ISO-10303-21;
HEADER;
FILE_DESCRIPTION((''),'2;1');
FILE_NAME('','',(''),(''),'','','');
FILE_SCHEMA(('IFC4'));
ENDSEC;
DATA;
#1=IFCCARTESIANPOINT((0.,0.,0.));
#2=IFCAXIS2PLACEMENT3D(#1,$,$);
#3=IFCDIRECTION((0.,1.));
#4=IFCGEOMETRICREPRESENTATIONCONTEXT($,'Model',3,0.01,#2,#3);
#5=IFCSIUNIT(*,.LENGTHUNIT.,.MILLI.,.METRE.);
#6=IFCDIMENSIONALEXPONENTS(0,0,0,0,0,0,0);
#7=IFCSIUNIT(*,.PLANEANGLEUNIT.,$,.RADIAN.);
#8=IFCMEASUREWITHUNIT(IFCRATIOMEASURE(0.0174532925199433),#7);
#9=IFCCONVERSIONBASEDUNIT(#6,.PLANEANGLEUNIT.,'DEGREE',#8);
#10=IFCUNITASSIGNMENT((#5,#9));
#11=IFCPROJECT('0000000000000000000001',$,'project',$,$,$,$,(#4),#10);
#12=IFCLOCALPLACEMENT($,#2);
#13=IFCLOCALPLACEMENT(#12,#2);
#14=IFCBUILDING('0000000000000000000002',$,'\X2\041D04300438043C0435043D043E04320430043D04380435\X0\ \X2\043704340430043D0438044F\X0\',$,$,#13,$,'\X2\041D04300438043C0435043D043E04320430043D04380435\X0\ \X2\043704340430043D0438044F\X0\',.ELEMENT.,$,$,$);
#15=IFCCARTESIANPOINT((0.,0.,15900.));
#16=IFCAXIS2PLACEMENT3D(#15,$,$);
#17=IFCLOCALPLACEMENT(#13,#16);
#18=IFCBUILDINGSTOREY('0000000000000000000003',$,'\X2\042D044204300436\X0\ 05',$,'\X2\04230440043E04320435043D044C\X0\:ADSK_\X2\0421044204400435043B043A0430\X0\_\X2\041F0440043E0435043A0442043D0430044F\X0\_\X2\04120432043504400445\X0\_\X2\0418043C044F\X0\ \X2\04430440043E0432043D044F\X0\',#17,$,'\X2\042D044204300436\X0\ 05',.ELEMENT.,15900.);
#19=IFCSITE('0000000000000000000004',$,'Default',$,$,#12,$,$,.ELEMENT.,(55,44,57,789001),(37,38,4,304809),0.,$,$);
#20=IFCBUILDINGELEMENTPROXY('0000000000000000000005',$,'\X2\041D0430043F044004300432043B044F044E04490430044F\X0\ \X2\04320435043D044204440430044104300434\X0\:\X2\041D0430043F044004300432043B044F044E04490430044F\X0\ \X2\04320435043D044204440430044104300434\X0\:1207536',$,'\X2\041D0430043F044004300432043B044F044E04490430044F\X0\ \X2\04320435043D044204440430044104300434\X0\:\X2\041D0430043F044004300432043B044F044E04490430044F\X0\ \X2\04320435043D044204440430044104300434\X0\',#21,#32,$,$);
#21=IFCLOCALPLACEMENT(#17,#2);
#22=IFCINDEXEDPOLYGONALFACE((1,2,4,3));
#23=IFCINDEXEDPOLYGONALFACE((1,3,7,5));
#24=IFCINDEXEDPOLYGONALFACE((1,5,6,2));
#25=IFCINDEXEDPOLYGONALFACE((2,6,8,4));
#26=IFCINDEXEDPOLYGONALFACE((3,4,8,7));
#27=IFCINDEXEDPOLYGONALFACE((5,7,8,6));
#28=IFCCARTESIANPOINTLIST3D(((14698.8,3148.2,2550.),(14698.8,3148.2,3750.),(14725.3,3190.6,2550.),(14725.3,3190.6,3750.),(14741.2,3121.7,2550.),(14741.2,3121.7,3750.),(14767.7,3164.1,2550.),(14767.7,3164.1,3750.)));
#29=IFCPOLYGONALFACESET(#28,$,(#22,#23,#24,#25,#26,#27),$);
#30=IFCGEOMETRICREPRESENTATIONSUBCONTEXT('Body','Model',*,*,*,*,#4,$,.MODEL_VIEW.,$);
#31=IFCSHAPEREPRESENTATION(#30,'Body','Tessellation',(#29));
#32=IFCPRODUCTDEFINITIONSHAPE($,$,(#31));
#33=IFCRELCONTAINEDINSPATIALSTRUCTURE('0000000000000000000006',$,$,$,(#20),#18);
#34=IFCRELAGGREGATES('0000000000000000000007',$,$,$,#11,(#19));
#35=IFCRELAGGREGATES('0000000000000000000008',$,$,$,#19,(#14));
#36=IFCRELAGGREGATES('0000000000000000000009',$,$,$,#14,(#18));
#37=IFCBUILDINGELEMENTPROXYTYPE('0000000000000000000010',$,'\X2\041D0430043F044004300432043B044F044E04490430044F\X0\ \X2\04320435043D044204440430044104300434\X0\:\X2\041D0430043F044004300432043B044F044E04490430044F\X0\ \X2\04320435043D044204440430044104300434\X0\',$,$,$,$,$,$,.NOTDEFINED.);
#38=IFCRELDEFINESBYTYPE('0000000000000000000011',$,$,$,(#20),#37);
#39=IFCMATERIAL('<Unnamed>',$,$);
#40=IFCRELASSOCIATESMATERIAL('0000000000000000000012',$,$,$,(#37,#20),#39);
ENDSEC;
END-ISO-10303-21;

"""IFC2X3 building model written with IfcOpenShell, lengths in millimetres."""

from ifc_helpers import new_model, entity, si_unit, converted_unit, direction, frame, origin, origin_2d_with_axis, place, context, subcontext, project, spatial, rectangle, extrude, source, transform, mapped, material, type_object, type_shapes, element, save


model = new_model("IFC2X3")

# Units and contexts
model_context = context("Model", 3, precision=0.01, world=origin(), true_north=direction((0.0, 1.0)))
body_context = subcontext(model_context, "Body", "Model", "MODEL_VIEW")
ifc_project = project(units=[si_unit("LENGTHUNIT", "METRE", prefix="MILLI"), converted_unit("PLANEANGLEUNIT", "DEGREE", entity("IfcRatioMeasure", 0.0174532925199433), si_unit("PLANEANGLEUNIT", "RADIAN"), dimensions=[0, 0, 0, 0, 0, 0, 0])], contexts=[model_context])

# Site, building, storey
site_placement = place(None, origin())
site = spatial("IfcSite", under=ifc_project, at=site_placement, Name="Default", CompositionType="ELEMENT", RefLatitude=(55, 44, 57, 789001), RefLongitude=(37, 38, 4, 304809), RefElevation=0.0)
building_placement = place(site_placement, origin())
building = spatial("IfcBuilding", under=site, at=building_placement, Name="Наименование здания", LongName="Наименование здания", CompositionType="ELEMENT")
storey_placement = place(building_placement, frame((0.0, 0.0, 15900.0)))
storey = spatial("IfcBuildingStorey", under=building, at=storey_placement, Name="Этаж 05", ObjectType="Уровень:ADSK_Стрелка_Проектная_Вверх_Имя уровня", LongName="Этаж 05", CompositionType="ELEMENT", Elevation=15900.0)

# Building element proxy
ifc_material_1 = material(Name="<Unnamed>")
building_element_proxy_type_1 = type_object("IfcBuildingElementProxyType", Name="Направляющая вентфасад:Направляющая вентфасад", PredefinedType="NOTDEFINED", material=ifc_material_1)
shared_shape_1 = source(origin(), body_context, "Body", "SweptSolid", [
    extrude(rectangle(XDim=50.0, YDim=50.0, at=origin_2d_with_axis()), frame((25.0, -25.0, 0.0), z_axis=(0.0, 0.0, 1.0), x_axis=(-1.0, 0.0, 0.0)), (0.0, 0.0, 1.0), 1200.0),
])
type_shapes(building_element_proxy_type_1, [shared_shape_1])
proxy_1_placement = place(storey_placement, frame((14725.3, 3190.6, 2550.0), z_axis=(0.0, 0.0, 1.0), x_axis=(0.848053, -0.529912, 0.0)))
element("IfcBuildingElementProxy", 1, at=proxy_1_placement, inside=storey, type_object=building_element_proxy_type_1, material=ifc_material_1, Name="Направляющая вентфасад:Направляющая вентфасад:1207536", ObjectType="Направляющая вентфасад:Направляющая вентфасад", context=body_context, shape_type="MappedRepresentation", body=[
    mapped(shared_shape_1, transform((0.0, 0.0, 0.0), scale=1.0)),
])

save(model, "model.ifc")
